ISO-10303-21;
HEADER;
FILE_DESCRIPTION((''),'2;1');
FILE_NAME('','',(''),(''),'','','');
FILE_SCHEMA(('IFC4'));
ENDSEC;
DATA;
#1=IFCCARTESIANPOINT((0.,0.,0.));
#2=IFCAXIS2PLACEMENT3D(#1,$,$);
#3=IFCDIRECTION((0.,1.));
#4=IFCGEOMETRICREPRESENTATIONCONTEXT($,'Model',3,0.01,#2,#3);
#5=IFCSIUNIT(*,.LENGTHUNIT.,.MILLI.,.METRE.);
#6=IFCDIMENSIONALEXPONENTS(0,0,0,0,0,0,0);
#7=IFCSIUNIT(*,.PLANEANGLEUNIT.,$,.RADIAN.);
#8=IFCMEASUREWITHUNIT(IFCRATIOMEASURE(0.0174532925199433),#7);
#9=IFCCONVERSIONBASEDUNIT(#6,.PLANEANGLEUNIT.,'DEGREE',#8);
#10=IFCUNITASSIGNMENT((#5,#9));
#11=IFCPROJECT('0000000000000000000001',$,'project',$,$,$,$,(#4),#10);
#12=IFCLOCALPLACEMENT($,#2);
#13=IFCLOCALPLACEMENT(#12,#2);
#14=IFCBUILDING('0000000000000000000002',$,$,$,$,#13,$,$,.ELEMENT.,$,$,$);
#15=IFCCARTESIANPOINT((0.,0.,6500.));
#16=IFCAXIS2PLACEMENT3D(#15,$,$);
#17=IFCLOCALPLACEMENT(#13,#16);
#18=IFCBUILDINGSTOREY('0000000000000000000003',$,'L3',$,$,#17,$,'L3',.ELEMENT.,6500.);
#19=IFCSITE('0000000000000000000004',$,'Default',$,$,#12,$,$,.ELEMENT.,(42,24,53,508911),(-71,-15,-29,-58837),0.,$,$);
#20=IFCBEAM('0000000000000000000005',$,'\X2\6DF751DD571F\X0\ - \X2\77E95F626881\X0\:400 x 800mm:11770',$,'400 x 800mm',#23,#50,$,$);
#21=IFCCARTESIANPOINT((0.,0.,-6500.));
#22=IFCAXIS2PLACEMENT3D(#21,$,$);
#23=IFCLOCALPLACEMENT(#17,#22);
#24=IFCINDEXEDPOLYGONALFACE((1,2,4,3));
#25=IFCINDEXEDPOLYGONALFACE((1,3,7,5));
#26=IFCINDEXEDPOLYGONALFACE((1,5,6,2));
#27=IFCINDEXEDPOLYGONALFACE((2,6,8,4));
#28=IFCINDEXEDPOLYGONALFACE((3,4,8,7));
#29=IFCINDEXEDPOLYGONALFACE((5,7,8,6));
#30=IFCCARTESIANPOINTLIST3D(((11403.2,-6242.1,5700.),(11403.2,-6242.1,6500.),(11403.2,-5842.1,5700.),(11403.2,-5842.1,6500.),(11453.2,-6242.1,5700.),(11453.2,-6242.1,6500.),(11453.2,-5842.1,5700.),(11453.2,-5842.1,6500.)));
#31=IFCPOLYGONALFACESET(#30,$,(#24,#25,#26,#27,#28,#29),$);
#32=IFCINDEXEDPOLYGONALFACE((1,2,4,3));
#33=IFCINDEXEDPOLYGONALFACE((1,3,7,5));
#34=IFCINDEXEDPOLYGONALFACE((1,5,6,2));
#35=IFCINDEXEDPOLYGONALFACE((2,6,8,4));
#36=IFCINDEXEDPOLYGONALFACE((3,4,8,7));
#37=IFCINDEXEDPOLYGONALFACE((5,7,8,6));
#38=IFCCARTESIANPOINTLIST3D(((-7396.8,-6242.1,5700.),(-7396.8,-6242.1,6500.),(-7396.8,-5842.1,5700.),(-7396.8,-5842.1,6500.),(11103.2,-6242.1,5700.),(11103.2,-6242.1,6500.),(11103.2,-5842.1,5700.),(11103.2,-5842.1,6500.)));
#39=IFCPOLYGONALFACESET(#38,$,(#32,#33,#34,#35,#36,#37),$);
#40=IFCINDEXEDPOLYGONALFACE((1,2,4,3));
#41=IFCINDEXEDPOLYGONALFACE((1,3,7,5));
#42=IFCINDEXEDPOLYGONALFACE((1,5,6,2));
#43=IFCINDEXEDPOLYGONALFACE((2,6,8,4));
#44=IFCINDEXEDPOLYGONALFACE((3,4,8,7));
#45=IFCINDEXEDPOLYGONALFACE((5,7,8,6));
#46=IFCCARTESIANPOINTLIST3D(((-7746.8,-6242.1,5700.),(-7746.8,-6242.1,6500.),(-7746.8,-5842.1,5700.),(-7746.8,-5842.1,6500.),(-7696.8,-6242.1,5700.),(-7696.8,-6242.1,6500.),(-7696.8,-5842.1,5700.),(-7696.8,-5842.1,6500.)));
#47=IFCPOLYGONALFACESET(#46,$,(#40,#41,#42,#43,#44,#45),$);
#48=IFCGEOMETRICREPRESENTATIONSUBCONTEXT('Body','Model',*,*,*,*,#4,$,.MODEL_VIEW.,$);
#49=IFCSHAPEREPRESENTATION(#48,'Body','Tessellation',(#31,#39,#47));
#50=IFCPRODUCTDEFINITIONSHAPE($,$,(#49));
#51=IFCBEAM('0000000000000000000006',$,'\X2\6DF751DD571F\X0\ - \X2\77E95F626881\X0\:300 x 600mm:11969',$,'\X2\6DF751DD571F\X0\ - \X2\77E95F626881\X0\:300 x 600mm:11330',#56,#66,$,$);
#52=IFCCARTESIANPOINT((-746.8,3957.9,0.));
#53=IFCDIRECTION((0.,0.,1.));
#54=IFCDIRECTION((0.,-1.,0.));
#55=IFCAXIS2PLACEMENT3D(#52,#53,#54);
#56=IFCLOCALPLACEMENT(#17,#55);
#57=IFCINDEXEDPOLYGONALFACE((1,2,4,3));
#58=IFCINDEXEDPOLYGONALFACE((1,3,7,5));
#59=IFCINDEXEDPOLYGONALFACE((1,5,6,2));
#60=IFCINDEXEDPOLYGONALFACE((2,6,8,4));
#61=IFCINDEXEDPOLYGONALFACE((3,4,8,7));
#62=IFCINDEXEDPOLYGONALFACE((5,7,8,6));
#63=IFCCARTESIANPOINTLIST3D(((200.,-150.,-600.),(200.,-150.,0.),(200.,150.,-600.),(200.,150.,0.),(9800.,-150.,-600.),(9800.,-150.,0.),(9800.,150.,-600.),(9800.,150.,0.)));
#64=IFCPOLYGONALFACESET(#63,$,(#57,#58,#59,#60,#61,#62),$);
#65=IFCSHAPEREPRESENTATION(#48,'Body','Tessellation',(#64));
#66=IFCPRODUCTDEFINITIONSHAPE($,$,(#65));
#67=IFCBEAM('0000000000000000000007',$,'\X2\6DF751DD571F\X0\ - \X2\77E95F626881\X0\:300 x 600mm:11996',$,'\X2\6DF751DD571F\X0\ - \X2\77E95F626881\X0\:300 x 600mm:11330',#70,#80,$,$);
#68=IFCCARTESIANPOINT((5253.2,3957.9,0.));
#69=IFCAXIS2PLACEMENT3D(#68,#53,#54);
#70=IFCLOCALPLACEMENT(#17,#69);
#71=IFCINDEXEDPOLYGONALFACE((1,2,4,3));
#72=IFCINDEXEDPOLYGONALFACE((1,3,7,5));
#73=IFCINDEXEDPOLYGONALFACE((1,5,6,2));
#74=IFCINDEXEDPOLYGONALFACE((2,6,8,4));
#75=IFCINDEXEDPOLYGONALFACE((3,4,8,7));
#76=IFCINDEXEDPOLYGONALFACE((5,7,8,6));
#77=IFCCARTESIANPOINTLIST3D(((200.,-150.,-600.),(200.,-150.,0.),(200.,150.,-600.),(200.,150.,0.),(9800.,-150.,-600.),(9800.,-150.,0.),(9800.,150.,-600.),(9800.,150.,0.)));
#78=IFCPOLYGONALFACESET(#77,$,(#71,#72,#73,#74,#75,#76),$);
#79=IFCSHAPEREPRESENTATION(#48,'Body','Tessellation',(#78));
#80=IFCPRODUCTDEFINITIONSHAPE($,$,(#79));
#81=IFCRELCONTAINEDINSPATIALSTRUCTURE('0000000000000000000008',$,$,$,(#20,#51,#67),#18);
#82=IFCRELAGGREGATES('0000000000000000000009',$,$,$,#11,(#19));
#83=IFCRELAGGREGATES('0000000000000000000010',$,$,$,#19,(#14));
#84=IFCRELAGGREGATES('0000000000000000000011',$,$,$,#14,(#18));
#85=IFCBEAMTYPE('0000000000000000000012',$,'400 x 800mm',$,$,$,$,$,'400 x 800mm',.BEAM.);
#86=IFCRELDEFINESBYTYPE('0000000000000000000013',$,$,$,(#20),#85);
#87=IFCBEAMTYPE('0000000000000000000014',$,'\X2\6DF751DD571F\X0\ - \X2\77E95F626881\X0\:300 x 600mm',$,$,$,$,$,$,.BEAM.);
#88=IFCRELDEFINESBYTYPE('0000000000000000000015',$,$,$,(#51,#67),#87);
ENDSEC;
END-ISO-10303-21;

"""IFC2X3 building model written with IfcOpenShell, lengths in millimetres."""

from ifc_helpers import new_model, entity, si_unit, converted_unit, direction, frame, frame_2d, origin, place, context, subcontext, project, spatial, rectangle, extrude, source, transform, mapped, type_object, type_shapes, element, save


model = new_model("IFC2X3")

# Units and contexts
model_context = context("Model", 3, precision=0.01, world=origin(), true_north=direction((0.0, 1.0)))
body_context = subcontext(model_context, "Body", "Model", "MODEL_VIEW")
ifc_project = project(units=[si_unit("LENGTHUNIT", "METRE", prefix="MILLI"), converted_unit("PLANEANGLEUNIT", "DEGREE", entity("IfcRatioMeasure", 0.0174532925199433), si_unit("PLANEANGLEUNIT", "RADIAN"), dimensions=[0, 0, 0, 0, 0, 0, 0])], contexts=[model_context])

# Site, building, storey
site_placement = place(None, origin())
site = spatial("IfcSite", under=ifc_project, at=site_placement, Name="Default", CompositionType="ELEMENT", RefLatitude=(42, 24, 53, 508911), RefLongitude=(-71, -15, -29, -58837), RefElevation=0.0)
building_placement = place(site_placement, origin())
building = spatial("IfcBuilding", under=site, at=building_placement, CompositionType="ELEMENT")
storey_placement = place(building_placement, frame((0.0, 0.0, 6500.0)))
storey = spatial("IfcBuildingStorey", under=building, at=storey_placement, Name="L3", LongName="L3", CompositionType="ELEMENT", Elevation=6500.0)

# Beams
beam_type_1 = type_object("IfcBeamType", Name="400 x 800mm", ElementType="400 x 800mm", PredefinedType="BEAM")
shared_shape_1 = source(origin(), body_context, "Body", "SweptSolid", [
    extrude(rectangle(XDim=50.0, YDim=400.0, at=frame_2d((0.0, 0.0), x_axis=(1.0, 0.0))), frame((11428.2, -6042.1, 5700.0), z_axis=(0.0, 0.0, 1.0), x_axis=(-1.0, 0.0, 0.0)), (0.0, 0.0, 1.0), 800.0),
    extrude(rectangle(XDim=18500.0, YDim=400.0, at=frame_2d((0.0, -66.7), x_axis=(1.0, 0.0))), frame((1853.2, -5975.5, 5700.0)), (0.0, 0.0, 1.0), 800.0),
    extrude(rectangle(XDim=50.0, YDim=400.0, at=frame_2d((0.0, 0.0), x_axis=(1.0, 0.0))), frame((-7721.8, -6042.1, 5700.0)), (0.0, 0.0, 1.0), 800.0),
])
type_shapes(beam_type_1, [shared_shape_1])
beam_1_placement = place(storey_placement, frame((0.0, 0.0, -6500.0)))
element("IfcBeam", 1, at=beam_1_placement, inside=storey, type_object=beam_type_1, Name="混凝土 - 矩形梁:400 x 800mm:11770", ObjectType="400 x 800mm", context=body_context, shape_type="MappedRepresentation", body=[
    mapped(shared_shape_1, transform((0.0, 0.0, 0.0), scale=1.0)),
])
beam_type_2 = type_object("IfcBeamType", Name="混凝土 - 矩形梁:300 x 600mm", PredefinedType="BEAM")
beam_2_placement = place(storey_placement, frame((-746.8, 3957.9, 0.0), z_axis=(0.0, 0.0, 1.0), x_axis=(0.0, -1.0, 0.0)))
element("IfcBeam", 2, at=beam_2_placement, inside=storey, type_object=beam_type_2, Name="混凝土 - 矩形梁:300 x 600mm:11969", ObjectType="混凝土 - 矩形梁:300 x 600mm:11330", context=body_context, shape_type="SweptSolid", body=[
    extrude(rectangle(XDim=600.0, YDim=300.0, at=frame_2d((0.0, 0.0), x_axis=(1.0, 0.0))), frame((200.0, 0.0, -300.0), z_axis=(1.0, 0.0, 0.0), x_axis=(0.0, 0.0, -1.0)), (0.0, 0.0, 1.0), 9600.0),
])
beam_3_placement = place(storey_placement, frame((5253.2, 3957.9, 0.0), z_axis=(0.0, 0.0, 1.0), x_axis=(0.0, -1.0, 0.0)))
element("IfcBeam", 3, at=beam_3_placement, inside=storey, type_object=beam_type_2, Name="混凝土 - 矩形梁:300 x 600mm:11996", ObjectType="混凝土 - 矩形梁:300 x 600mm:11330", context=body_context, shape_type="SweptSolid", body=[
    extrude(rectangle(XDim=600.0, YDim=300.0, at=frame_2d((0.0, 0.0), x_axis=(1.0, 0.0))), frame((200.0, 0.0, -300.0), z_axis=(1.0, 0.0, 0.0), x_axis=(0.0, 0.0, -1.0)), (0.0, 0.0, 1.0), 9600.0),
])

save(model, "model.ifc")
